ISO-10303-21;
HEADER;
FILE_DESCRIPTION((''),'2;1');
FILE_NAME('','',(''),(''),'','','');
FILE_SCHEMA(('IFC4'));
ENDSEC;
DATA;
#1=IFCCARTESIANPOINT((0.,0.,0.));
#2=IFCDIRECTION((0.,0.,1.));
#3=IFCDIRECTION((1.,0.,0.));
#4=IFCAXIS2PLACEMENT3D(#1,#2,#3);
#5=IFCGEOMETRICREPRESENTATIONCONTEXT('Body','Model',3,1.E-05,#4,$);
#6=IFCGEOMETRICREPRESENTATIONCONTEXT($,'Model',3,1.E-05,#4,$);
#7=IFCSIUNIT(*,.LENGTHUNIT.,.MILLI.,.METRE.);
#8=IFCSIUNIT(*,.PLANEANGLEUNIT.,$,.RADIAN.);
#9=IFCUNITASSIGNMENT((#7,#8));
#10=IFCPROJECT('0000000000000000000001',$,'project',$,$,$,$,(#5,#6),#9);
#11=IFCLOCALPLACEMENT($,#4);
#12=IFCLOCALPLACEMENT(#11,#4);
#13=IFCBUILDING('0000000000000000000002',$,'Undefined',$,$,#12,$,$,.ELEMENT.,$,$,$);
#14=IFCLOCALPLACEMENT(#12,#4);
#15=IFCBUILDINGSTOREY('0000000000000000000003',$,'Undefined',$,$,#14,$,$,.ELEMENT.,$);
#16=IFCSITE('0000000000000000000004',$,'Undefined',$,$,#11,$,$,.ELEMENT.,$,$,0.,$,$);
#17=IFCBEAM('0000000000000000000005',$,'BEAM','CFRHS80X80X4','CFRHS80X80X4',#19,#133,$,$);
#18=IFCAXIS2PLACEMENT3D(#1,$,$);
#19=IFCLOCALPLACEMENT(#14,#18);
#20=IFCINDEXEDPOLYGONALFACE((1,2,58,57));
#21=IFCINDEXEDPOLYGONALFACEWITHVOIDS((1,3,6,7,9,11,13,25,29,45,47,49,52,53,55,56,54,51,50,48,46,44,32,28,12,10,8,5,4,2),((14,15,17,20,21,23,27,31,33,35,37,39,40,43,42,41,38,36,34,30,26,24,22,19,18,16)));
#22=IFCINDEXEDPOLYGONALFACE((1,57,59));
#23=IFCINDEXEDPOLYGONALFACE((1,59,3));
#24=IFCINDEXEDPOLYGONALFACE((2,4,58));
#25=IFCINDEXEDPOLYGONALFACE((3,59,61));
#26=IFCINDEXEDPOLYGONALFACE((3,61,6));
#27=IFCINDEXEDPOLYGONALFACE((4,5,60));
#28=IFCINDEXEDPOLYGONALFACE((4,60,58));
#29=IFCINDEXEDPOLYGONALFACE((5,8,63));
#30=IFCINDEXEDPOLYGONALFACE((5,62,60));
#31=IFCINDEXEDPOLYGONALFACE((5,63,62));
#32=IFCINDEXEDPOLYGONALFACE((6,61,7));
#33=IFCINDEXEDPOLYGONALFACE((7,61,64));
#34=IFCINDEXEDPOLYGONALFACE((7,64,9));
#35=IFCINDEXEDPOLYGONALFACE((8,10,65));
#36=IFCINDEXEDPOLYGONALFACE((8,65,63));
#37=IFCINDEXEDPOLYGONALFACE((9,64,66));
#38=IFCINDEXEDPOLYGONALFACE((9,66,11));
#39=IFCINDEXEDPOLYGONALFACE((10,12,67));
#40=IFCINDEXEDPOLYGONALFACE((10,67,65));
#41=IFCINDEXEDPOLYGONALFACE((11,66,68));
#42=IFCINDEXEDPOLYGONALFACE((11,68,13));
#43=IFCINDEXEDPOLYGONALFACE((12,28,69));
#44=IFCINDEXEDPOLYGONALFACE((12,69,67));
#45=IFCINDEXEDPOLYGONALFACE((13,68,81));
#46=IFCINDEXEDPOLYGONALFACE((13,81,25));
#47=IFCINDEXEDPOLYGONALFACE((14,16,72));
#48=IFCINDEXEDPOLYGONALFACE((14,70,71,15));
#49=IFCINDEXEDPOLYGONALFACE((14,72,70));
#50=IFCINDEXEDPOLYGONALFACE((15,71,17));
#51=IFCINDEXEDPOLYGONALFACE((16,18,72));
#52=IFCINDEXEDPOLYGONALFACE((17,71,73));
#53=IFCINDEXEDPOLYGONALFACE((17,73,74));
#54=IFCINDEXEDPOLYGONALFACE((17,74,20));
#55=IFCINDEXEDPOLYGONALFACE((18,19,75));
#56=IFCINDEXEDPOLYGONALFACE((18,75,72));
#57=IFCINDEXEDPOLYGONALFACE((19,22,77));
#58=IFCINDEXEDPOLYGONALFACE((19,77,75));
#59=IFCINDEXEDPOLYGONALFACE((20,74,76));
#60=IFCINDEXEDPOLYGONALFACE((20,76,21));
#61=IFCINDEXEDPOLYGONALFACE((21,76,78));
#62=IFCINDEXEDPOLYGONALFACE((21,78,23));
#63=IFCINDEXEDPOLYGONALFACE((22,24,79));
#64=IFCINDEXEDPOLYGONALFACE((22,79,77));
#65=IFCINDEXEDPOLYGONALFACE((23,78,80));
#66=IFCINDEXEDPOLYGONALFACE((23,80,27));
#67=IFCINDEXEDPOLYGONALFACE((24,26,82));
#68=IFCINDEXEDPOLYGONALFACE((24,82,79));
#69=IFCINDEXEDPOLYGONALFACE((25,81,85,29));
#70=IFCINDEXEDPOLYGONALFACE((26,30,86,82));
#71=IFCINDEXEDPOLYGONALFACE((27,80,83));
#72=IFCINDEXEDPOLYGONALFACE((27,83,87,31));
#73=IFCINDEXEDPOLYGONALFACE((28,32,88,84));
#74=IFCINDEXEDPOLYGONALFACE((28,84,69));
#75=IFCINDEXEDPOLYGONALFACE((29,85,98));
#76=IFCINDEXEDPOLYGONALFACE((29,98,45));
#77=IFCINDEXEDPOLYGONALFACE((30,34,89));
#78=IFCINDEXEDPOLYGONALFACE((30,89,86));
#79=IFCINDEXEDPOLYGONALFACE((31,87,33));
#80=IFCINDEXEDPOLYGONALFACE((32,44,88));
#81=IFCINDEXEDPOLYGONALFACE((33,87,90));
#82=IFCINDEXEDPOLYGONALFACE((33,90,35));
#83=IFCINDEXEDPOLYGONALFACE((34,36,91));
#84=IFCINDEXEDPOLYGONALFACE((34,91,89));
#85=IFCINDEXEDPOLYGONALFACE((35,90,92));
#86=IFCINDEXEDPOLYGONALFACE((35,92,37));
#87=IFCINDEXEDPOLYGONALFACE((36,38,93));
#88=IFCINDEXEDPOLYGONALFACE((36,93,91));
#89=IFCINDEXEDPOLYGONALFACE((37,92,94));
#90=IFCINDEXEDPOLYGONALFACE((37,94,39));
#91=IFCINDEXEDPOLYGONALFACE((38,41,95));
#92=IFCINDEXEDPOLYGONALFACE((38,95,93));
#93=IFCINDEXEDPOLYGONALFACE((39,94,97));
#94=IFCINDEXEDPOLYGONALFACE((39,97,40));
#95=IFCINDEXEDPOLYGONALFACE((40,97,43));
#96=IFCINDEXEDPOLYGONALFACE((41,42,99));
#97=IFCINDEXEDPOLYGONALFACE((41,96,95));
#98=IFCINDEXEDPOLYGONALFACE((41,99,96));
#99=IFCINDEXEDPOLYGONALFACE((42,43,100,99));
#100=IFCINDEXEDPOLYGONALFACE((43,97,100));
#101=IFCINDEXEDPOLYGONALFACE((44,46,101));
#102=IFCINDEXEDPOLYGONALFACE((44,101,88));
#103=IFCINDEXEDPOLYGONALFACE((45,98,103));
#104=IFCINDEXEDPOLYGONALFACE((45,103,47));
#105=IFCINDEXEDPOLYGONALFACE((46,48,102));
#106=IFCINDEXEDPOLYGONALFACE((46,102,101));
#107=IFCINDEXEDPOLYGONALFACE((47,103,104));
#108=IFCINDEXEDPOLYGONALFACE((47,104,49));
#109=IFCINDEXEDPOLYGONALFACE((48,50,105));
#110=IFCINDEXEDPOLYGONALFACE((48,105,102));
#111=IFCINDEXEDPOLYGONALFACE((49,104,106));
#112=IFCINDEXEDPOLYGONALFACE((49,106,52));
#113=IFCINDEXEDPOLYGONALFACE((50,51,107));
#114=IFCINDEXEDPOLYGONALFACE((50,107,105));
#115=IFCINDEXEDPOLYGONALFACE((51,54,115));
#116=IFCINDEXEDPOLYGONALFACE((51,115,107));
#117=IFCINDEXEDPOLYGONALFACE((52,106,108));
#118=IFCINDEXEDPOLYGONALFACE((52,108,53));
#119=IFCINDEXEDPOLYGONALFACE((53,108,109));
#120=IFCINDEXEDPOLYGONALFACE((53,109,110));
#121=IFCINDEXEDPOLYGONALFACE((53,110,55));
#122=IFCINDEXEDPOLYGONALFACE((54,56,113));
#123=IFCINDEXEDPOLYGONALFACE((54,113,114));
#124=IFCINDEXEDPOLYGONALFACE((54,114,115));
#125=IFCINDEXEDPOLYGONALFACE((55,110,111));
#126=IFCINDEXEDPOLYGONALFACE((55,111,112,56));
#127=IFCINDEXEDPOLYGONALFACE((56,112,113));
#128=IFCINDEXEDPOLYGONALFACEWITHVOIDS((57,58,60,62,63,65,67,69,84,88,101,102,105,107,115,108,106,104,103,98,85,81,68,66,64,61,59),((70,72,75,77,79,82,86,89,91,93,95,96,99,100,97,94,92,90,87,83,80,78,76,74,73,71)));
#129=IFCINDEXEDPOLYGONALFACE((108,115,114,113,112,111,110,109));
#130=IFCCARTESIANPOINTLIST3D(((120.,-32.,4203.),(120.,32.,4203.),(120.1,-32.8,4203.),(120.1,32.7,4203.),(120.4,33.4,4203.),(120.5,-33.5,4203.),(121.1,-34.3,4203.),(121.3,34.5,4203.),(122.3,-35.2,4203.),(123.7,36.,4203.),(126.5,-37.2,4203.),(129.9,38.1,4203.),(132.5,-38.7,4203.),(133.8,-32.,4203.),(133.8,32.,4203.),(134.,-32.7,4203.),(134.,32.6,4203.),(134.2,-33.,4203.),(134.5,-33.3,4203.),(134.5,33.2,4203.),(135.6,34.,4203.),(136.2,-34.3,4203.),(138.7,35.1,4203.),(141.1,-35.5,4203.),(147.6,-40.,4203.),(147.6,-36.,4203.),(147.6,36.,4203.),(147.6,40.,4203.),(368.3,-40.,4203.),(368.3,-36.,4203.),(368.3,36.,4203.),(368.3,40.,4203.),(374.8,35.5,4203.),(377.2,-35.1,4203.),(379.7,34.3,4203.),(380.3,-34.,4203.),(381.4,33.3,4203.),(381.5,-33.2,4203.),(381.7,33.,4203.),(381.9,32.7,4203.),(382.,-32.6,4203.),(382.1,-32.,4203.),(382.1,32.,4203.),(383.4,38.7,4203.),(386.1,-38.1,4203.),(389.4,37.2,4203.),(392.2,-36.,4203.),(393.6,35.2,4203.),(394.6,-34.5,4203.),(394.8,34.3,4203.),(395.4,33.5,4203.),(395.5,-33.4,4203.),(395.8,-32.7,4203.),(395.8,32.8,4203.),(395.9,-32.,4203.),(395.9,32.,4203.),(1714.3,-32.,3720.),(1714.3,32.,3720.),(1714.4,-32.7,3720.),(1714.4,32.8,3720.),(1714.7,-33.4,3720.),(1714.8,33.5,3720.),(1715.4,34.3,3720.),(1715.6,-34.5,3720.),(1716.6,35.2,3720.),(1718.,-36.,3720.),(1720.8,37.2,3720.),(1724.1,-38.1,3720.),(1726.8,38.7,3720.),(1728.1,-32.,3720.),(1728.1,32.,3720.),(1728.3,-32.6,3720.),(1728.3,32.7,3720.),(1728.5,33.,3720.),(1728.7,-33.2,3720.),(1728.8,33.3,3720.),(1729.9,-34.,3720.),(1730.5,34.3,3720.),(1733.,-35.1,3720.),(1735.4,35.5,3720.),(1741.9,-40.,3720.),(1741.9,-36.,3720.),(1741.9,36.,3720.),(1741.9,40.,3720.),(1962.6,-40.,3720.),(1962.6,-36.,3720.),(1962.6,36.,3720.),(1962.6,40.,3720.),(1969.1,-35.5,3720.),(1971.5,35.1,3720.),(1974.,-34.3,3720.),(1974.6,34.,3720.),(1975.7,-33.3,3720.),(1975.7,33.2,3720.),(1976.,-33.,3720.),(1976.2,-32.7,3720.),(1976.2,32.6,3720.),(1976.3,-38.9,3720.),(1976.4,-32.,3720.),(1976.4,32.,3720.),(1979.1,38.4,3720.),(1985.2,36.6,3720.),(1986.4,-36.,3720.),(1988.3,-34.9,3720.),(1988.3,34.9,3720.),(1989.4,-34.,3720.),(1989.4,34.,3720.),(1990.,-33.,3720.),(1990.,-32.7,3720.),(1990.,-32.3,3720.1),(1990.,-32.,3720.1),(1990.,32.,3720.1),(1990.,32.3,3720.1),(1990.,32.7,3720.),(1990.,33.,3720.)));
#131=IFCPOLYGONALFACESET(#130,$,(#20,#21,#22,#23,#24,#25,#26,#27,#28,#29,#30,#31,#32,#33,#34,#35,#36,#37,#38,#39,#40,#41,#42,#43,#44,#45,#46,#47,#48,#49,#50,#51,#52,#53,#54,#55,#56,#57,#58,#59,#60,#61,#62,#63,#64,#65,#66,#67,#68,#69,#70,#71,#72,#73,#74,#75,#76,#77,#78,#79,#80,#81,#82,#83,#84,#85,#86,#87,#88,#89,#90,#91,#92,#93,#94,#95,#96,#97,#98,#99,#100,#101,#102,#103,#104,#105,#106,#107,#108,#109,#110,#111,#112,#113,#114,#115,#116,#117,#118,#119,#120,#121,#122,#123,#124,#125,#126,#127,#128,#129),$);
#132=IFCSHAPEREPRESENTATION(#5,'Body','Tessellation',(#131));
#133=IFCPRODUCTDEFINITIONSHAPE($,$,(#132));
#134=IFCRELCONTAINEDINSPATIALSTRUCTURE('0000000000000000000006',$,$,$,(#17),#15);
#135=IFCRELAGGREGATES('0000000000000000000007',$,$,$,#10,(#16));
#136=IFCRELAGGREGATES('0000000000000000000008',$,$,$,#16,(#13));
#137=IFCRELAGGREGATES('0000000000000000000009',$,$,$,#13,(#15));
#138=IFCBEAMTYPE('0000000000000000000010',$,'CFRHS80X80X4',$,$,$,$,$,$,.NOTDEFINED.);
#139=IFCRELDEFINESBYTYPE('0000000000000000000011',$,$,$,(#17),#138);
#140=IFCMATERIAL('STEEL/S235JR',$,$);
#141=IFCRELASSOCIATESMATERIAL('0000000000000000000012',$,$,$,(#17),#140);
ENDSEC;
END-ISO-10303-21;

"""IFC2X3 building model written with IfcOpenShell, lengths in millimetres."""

from ifc_helpers import new_model, si_unit, frame, origin_with_axes, origin_2d_with_axis, place, context, project, spatial, hollow_rectangle, extrude, clip, halfspace, material, type_object, element, save


model = new_model("IFC2X3")

# Units and contexts
model_context_1 = context("Model", 3, precision=1e-05, world=origin_with_axes(), identifier="Body")
model_context_2 = context("Model", 3, precision=1e-05, world=origin_with_axes())
ifc_project = project(units=[si_unit("LENGTHUNIT", "METRE", prefix="MILLI"), si_unit("PLANEANGLEUNIT", "RADIAN")], contexts=[model_context_1, model_context_2])

# Site, building, storey
site_placement = place(None, origin_with_axes())
site = spatial("IfcSite", under=ifc_project, at=site_placement, Name="Undefined", CompositionType="ELEMENT", RefElevation=0.0)
building_placement = place(site_placement, origin_with_axes())
building = spatial("IfcBuilding", under=site, at=building_placement, Name="Undefined", CompositionType="ELEMENT")
storey_placement = place(building_placement, origin_with_axes())
storey = spatial("IfcBuildingStorey", under=building, at=storey_placement, Name="Undefined", CompositionType="ELEMENT")

# Shared definitions
ifc_material = material(Name="STEEL/S235JR")

# Beam
beam_type_1 = type_object("IfcBeamType", Name="CFRHS80X80X4", PredefinedType="NOTDEFINED")
beam_1_placement = place(storey_placement, frame((131.6, 0.0, 4241.3), z_axis=(0.0, -1.0, 0.0), x_axis=(0.957044, 0.0, -0.289943)))
element("IfcBeam", 1, at=beam_1_placement, inside=storey, type_object=beam_type_1, material=ifc_material, Name="BEAM", Description="CFRHS80X80X4", ObjectType="CFRHS80X80X4", context=model_context_1, shape_type="Clipping", body=[
    clip(clip(clip(extrude(hollow_rectangle(XDim=80.0, YDim=80.0, WallThickness=4.0, InnerFilletRadius=4.0, OuterFilletRadius=8.0, at=origin_2d_with_axis()), frame((1929.7, 0.0, 0.0), z_axis=(-1.0, 0.0, 0.0), x_axis=(0.0, -1.0, 0.0)), (0.0, 0.0, 1.0), 1929.7), halfspace(frame((1929.9, 40.0, -40.0), z_axis=(0.289943, -0.957044, 0.0), x_axis=(-0.957044, -0.289943, 0.0)), False)), halfspace(frame((0.0, -40.0, -40.0), z_axis=(-0.289943, 0.957044, 0.0), x_axis=(0.957044, 0.289943, 0.0)), False)), halfspace(frame((0.0, -40.0, -40.0), z_axis=(-0.289943, 0.957044, 0.0), x_axis=(0.957044, 0.289943, 0.0)), False)),
])

save(model, "model.ifc")
